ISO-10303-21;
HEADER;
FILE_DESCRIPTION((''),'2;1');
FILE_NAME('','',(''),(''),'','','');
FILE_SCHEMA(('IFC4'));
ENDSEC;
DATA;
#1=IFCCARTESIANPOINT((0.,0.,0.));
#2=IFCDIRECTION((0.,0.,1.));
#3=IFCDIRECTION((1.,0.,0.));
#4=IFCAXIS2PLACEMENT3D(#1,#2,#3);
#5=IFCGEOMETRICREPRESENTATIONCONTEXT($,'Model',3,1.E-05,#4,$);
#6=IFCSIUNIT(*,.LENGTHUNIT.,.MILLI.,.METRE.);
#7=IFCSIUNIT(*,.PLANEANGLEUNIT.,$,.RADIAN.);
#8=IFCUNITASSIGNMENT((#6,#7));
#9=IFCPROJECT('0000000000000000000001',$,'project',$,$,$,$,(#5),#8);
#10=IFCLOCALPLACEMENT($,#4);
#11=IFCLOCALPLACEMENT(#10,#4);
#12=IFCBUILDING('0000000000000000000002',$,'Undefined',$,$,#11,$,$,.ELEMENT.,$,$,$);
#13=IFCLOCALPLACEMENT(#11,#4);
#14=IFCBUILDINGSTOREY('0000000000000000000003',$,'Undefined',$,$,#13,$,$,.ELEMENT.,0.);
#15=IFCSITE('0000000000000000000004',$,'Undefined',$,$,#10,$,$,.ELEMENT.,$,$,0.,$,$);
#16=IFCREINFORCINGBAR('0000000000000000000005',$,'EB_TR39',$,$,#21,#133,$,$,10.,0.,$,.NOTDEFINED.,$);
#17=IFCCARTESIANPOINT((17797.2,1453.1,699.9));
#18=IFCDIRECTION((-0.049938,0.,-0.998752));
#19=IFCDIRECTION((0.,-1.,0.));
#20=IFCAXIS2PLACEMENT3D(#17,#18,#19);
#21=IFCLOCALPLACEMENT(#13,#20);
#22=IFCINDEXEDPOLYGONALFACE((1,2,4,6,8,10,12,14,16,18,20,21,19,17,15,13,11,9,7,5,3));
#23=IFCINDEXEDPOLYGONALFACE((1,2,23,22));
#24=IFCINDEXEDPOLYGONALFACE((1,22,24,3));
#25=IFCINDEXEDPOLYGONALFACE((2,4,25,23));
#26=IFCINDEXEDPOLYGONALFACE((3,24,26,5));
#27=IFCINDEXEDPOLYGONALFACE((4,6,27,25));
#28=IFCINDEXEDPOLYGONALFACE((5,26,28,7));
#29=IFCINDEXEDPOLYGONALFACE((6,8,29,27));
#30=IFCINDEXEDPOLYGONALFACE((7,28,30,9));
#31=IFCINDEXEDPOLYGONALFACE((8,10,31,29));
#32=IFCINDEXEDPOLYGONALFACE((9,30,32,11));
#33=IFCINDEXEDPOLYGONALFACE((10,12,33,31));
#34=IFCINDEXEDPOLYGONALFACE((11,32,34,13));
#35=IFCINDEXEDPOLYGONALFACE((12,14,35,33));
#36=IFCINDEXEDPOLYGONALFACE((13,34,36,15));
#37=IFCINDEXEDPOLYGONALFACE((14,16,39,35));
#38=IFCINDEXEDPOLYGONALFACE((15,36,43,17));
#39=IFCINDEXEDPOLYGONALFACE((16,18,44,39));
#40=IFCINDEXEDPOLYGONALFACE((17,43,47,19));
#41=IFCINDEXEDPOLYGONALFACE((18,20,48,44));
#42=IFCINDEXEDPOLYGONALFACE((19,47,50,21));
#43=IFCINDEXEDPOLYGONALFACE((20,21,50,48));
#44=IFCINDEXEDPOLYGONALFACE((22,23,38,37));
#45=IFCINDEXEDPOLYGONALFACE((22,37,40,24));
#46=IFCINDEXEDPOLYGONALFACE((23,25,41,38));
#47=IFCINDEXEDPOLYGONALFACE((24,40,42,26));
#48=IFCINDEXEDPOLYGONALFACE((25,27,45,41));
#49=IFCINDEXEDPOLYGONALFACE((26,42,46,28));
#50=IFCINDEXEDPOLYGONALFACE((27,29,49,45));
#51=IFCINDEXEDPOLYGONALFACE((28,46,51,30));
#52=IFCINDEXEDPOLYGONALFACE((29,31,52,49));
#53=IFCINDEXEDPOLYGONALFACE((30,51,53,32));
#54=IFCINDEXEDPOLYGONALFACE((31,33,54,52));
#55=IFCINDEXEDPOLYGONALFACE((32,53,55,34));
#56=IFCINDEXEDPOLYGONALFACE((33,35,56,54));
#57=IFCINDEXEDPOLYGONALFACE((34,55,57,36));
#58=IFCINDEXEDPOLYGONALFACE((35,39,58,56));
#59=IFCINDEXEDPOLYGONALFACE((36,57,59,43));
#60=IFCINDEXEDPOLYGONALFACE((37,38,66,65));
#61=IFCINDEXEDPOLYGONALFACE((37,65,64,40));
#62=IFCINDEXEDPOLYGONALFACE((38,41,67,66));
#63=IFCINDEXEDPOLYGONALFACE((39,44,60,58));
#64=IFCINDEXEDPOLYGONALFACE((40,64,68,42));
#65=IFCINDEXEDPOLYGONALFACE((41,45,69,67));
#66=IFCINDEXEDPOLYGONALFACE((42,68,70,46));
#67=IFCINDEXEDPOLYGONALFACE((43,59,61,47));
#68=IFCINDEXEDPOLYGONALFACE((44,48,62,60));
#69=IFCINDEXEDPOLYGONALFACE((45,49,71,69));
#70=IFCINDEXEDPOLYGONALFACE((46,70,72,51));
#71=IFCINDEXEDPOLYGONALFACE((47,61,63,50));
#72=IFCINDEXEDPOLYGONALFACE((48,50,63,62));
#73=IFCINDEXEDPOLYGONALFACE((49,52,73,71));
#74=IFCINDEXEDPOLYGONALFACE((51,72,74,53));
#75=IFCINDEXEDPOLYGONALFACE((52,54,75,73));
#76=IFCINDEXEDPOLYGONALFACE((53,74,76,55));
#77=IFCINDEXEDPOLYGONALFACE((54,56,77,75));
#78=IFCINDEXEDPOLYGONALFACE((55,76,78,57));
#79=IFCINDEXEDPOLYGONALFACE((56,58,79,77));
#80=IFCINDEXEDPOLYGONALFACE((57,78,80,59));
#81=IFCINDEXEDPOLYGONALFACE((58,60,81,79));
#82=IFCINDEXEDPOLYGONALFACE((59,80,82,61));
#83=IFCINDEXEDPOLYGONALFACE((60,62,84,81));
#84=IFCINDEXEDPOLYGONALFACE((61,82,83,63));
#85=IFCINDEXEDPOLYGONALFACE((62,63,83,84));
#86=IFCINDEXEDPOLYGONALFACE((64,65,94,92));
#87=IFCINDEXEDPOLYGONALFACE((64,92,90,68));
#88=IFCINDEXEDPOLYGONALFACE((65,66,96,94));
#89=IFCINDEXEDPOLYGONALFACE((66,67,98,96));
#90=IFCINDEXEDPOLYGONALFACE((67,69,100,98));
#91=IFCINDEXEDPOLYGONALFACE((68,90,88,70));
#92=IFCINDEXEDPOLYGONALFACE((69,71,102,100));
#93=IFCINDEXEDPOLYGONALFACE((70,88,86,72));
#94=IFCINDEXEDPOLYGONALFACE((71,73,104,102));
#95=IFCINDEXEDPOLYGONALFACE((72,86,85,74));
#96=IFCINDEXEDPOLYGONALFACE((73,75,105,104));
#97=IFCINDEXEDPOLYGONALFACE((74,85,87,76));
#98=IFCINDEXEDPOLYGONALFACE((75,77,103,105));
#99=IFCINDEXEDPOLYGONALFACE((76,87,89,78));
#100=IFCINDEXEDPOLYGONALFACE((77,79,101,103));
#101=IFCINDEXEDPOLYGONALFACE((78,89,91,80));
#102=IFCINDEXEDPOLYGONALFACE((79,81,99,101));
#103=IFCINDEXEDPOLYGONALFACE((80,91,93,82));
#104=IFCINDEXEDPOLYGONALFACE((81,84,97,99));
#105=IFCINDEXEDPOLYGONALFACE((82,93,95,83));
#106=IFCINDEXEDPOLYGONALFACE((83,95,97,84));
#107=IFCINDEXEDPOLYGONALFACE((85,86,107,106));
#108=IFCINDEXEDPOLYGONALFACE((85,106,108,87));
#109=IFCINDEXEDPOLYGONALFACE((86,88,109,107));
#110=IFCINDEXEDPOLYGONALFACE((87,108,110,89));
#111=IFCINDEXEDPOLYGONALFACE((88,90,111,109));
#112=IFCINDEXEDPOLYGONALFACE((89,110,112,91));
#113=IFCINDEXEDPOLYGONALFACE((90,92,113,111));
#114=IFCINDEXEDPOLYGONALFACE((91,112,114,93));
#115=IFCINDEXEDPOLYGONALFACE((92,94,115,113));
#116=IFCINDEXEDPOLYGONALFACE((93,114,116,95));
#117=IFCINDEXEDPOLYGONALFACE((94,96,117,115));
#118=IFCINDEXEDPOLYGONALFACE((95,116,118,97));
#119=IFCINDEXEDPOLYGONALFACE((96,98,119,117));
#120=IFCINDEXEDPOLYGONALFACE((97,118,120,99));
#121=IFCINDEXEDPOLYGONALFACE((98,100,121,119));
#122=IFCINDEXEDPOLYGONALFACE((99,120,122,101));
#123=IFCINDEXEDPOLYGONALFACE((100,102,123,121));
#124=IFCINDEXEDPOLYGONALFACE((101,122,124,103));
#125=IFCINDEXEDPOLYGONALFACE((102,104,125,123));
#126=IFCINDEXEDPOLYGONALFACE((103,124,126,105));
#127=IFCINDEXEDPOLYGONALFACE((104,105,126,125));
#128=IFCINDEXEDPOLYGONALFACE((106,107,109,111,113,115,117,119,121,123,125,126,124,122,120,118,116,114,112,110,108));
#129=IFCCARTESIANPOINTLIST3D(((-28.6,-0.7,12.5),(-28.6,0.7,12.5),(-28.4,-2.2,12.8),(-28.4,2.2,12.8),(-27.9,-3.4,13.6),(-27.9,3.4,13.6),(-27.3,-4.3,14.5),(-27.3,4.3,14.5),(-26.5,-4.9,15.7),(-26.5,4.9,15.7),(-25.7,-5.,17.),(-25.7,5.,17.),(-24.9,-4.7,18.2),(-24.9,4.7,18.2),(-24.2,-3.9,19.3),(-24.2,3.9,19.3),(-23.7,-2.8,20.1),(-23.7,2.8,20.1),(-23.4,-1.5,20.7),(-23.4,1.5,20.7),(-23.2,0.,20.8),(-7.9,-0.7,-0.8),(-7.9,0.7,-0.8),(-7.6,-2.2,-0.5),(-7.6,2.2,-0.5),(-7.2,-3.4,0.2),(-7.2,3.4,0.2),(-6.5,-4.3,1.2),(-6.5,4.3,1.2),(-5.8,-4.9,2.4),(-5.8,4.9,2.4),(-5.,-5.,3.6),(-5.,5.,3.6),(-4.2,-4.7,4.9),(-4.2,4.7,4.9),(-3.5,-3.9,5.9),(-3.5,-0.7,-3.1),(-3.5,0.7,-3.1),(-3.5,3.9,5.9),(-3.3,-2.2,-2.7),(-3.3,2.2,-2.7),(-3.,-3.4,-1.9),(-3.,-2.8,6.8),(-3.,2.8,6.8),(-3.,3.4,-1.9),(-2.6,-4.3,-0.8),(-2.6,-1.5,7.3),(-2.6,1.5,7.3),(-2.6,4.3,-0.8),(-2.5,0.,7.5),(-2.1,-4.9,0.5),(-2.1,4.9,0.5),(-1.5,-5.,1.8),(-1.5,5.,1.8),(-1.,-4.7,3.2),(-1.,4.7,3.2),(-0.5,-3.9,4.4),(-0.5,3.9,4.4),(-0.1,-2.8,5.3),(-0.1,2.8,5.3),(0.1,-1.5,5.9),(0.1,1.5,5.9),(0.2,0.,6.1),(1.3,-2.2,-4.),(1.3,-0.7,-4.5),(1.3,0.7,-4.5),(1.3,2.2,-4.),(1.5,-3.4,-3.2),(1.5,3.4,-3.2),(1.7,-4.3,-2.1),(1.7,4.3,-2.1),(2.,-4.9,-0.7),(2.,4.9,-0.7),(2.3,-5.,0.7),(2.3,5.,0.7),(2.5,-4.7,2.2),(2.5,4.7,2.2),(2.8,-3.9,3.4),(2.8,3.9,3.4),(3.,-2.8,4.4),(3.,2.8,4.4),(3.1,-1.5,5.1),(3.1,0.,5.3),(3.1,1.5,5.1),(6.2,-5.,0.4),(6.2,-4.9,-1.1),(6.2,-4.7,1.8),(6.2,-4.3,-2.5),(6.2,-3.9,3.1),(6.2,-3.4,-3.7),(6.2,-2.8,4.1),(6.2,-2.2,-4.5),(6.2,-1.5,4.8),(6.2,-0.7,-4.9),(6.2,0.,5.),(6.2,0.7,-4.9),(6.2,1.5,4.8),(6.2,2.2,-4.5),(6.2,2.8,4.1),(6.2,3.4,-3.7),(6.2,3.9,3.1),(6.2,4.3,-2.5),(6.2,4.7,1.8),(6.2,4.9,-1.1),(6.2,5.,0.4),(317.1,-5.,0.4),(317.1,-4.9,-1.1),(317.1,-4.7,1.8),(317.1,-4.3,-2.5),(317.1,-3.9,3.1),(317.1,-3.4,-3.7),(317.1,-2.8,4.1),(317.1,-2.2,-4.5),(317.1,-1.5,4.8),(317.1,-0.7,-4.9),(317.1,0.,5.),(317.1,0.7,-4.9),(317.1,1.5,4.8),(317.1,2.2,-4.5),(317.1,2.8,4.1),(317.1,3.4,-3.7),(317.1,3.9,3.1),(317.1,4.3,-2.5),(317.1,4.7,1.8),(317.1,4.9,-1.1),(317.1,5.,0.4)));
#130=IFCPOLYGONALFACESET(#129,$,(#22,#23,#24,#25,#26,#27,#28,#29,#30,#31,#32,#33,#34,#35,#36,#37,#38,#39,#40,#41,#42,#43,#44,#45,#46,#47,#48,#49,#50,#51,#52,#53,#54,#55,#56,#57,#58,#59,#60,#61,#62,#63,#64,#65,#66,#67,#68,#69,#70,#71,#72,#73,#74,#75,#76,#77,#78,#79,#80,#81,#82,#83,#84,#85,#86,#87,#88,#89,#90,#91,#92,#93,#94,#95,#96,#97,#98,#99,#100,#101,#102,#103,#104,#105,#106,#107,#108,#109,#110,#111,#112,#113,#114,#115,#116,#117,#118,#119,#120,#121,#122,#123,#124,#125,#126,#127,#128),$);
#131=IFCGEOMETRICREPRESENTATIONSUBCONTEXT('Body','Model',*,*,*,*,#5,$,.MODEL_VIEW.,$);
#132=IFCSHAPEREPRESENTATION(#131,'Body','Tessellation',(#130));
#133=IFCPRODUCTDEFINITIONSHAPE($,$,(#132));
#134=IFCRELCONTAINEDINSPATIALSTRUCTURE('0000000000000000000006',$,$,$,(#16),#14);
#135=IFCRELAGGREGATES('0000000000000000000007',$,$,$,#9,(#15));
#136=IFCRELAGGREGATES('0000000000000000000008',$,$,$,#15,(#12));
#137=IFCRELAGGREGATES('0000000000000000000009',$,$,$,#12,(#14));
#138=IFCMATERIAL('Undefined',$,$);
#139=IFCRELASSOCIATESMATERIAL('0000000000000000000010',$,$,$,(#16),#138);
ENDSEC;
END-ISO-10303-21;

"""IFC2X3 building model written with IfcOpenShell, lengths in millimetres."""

from ifc_helpers import new_model, entity, si_unit, frame, origin_with_axes, place, context, subcontext, project, spatial, source, transform, mapped, material, element, save


model = new_model("IFC2X3")

# Units and contexts
model_context = context("Model", 3, precision=1e-05, world=origin_with_axes())
body_context = subcontext(model_context, "Body", "Model", "MODEL_VIEW")
ifc_project = project(units=[si_unit("LENGTHUNIT", "METRE", prefix="MILLI"), si_unit("PLANEANGLEUNIT", "RADIAN")], contexts=[model_context])

# Site, building, storey
site_placement = place(None, origin_with_axes())
site = spatial("IfcSite", under=ifc_project, at=site_placement, Name="Undefined", CompositionType="ELEMENT", RefElevation=0.0)
building_placement = place(site_placement, origin_with_axes())
building = spatial("IfcBuilding", under=site, at=building_placement, Name="Undefined", CompositionType="ELEMENT")
storey_placement = place(building_placement, origin_with_axes())
storey = spatial("IfcBuildingStorey", under=building, at=storey_placement, Name="Undefined", CompositionType="ELEMENT", Elevation=0.0)

# Reinforcing bar
ifc_material_1 = material(Name="Undefined")
shared_shape_1 = source(origin_with_axes(), body_context, "Body", "AdvancedSweptSolid", [
    entity("IfcSweptDiskSolid", entity("IfcCompositeCurve", [entity("IfcCompositeCurveSegment", "CONTINUOUS", True, entity("IfcTrimmedCurve", entity("IfcLine", entity("IfcCartesianPoint", [0.0, 0.0, 0.0]), entity("IfcVector", entity("IfcDirection", [0.841694, 0.0, -0.539955]), 1.0)), [entity("IfcParameterValue", 0.0)], [entity("IfcParameterValue", 24.65374)], True, "PARAMETER")), entity("IfcCompositeCurveSegment", "CONTINUOUS", True, entity("IfcTrimmedCurve", entity("IfcCircle", entity("IfcAxis2Placement3D", entity("IfcCartesianPoint", [32.1, 0.0, 4.4]), entity("IfcDirection", [0.0, -1.0, 0.0]), entity("IfcDirection", [-0.539955, 0.0, -0.841694])), 21.0), [entity("IfcParameterValue", 0.0)], [entity("IfcParameterValue", 0.570383)], True, "PARAMETER")), entity("IfcCompositeCurveSegment", "DISCONTINUOUS", True, entity("IfcTrimmedCurve", entity("IfcLine", entity("IfcCartesianPoint", [32.1, 0.0, -16.6]), entity("IfcVector", entity("IfcDirection", [1.0, 0.0, 0.0]), 1.0)), [entity("IfcParameterValue", 0.0)], [entity("IfcParameterValue", 310.940714)], True, "PARAMETER"))], False), 5.0, None, 0.0, 336.2),
])
reinforcing_bar_1_placement = place(storey_placement, frame((17797.2, 1453.1, 699.9), z_axis=(-0.049938, 0.0, -0.998752), x_axis=(0.0, -1.0, 0.0)))
element("IfcReinforcingBar", 1, at=reinforcing_bar_1_placement, inside=storey, material=ifc_material_1, Name="EB_TR39", BarRole="NOTDEFINED", CrossSectionArea=0.0, NominalDiameter=10.0, context=body_context, shape_type="MappedRepresentation", body=[
    mapped(shared_shape_1, transform((-25.9, 0.0, 16.6))),
])

save(model, "model.ifc")
